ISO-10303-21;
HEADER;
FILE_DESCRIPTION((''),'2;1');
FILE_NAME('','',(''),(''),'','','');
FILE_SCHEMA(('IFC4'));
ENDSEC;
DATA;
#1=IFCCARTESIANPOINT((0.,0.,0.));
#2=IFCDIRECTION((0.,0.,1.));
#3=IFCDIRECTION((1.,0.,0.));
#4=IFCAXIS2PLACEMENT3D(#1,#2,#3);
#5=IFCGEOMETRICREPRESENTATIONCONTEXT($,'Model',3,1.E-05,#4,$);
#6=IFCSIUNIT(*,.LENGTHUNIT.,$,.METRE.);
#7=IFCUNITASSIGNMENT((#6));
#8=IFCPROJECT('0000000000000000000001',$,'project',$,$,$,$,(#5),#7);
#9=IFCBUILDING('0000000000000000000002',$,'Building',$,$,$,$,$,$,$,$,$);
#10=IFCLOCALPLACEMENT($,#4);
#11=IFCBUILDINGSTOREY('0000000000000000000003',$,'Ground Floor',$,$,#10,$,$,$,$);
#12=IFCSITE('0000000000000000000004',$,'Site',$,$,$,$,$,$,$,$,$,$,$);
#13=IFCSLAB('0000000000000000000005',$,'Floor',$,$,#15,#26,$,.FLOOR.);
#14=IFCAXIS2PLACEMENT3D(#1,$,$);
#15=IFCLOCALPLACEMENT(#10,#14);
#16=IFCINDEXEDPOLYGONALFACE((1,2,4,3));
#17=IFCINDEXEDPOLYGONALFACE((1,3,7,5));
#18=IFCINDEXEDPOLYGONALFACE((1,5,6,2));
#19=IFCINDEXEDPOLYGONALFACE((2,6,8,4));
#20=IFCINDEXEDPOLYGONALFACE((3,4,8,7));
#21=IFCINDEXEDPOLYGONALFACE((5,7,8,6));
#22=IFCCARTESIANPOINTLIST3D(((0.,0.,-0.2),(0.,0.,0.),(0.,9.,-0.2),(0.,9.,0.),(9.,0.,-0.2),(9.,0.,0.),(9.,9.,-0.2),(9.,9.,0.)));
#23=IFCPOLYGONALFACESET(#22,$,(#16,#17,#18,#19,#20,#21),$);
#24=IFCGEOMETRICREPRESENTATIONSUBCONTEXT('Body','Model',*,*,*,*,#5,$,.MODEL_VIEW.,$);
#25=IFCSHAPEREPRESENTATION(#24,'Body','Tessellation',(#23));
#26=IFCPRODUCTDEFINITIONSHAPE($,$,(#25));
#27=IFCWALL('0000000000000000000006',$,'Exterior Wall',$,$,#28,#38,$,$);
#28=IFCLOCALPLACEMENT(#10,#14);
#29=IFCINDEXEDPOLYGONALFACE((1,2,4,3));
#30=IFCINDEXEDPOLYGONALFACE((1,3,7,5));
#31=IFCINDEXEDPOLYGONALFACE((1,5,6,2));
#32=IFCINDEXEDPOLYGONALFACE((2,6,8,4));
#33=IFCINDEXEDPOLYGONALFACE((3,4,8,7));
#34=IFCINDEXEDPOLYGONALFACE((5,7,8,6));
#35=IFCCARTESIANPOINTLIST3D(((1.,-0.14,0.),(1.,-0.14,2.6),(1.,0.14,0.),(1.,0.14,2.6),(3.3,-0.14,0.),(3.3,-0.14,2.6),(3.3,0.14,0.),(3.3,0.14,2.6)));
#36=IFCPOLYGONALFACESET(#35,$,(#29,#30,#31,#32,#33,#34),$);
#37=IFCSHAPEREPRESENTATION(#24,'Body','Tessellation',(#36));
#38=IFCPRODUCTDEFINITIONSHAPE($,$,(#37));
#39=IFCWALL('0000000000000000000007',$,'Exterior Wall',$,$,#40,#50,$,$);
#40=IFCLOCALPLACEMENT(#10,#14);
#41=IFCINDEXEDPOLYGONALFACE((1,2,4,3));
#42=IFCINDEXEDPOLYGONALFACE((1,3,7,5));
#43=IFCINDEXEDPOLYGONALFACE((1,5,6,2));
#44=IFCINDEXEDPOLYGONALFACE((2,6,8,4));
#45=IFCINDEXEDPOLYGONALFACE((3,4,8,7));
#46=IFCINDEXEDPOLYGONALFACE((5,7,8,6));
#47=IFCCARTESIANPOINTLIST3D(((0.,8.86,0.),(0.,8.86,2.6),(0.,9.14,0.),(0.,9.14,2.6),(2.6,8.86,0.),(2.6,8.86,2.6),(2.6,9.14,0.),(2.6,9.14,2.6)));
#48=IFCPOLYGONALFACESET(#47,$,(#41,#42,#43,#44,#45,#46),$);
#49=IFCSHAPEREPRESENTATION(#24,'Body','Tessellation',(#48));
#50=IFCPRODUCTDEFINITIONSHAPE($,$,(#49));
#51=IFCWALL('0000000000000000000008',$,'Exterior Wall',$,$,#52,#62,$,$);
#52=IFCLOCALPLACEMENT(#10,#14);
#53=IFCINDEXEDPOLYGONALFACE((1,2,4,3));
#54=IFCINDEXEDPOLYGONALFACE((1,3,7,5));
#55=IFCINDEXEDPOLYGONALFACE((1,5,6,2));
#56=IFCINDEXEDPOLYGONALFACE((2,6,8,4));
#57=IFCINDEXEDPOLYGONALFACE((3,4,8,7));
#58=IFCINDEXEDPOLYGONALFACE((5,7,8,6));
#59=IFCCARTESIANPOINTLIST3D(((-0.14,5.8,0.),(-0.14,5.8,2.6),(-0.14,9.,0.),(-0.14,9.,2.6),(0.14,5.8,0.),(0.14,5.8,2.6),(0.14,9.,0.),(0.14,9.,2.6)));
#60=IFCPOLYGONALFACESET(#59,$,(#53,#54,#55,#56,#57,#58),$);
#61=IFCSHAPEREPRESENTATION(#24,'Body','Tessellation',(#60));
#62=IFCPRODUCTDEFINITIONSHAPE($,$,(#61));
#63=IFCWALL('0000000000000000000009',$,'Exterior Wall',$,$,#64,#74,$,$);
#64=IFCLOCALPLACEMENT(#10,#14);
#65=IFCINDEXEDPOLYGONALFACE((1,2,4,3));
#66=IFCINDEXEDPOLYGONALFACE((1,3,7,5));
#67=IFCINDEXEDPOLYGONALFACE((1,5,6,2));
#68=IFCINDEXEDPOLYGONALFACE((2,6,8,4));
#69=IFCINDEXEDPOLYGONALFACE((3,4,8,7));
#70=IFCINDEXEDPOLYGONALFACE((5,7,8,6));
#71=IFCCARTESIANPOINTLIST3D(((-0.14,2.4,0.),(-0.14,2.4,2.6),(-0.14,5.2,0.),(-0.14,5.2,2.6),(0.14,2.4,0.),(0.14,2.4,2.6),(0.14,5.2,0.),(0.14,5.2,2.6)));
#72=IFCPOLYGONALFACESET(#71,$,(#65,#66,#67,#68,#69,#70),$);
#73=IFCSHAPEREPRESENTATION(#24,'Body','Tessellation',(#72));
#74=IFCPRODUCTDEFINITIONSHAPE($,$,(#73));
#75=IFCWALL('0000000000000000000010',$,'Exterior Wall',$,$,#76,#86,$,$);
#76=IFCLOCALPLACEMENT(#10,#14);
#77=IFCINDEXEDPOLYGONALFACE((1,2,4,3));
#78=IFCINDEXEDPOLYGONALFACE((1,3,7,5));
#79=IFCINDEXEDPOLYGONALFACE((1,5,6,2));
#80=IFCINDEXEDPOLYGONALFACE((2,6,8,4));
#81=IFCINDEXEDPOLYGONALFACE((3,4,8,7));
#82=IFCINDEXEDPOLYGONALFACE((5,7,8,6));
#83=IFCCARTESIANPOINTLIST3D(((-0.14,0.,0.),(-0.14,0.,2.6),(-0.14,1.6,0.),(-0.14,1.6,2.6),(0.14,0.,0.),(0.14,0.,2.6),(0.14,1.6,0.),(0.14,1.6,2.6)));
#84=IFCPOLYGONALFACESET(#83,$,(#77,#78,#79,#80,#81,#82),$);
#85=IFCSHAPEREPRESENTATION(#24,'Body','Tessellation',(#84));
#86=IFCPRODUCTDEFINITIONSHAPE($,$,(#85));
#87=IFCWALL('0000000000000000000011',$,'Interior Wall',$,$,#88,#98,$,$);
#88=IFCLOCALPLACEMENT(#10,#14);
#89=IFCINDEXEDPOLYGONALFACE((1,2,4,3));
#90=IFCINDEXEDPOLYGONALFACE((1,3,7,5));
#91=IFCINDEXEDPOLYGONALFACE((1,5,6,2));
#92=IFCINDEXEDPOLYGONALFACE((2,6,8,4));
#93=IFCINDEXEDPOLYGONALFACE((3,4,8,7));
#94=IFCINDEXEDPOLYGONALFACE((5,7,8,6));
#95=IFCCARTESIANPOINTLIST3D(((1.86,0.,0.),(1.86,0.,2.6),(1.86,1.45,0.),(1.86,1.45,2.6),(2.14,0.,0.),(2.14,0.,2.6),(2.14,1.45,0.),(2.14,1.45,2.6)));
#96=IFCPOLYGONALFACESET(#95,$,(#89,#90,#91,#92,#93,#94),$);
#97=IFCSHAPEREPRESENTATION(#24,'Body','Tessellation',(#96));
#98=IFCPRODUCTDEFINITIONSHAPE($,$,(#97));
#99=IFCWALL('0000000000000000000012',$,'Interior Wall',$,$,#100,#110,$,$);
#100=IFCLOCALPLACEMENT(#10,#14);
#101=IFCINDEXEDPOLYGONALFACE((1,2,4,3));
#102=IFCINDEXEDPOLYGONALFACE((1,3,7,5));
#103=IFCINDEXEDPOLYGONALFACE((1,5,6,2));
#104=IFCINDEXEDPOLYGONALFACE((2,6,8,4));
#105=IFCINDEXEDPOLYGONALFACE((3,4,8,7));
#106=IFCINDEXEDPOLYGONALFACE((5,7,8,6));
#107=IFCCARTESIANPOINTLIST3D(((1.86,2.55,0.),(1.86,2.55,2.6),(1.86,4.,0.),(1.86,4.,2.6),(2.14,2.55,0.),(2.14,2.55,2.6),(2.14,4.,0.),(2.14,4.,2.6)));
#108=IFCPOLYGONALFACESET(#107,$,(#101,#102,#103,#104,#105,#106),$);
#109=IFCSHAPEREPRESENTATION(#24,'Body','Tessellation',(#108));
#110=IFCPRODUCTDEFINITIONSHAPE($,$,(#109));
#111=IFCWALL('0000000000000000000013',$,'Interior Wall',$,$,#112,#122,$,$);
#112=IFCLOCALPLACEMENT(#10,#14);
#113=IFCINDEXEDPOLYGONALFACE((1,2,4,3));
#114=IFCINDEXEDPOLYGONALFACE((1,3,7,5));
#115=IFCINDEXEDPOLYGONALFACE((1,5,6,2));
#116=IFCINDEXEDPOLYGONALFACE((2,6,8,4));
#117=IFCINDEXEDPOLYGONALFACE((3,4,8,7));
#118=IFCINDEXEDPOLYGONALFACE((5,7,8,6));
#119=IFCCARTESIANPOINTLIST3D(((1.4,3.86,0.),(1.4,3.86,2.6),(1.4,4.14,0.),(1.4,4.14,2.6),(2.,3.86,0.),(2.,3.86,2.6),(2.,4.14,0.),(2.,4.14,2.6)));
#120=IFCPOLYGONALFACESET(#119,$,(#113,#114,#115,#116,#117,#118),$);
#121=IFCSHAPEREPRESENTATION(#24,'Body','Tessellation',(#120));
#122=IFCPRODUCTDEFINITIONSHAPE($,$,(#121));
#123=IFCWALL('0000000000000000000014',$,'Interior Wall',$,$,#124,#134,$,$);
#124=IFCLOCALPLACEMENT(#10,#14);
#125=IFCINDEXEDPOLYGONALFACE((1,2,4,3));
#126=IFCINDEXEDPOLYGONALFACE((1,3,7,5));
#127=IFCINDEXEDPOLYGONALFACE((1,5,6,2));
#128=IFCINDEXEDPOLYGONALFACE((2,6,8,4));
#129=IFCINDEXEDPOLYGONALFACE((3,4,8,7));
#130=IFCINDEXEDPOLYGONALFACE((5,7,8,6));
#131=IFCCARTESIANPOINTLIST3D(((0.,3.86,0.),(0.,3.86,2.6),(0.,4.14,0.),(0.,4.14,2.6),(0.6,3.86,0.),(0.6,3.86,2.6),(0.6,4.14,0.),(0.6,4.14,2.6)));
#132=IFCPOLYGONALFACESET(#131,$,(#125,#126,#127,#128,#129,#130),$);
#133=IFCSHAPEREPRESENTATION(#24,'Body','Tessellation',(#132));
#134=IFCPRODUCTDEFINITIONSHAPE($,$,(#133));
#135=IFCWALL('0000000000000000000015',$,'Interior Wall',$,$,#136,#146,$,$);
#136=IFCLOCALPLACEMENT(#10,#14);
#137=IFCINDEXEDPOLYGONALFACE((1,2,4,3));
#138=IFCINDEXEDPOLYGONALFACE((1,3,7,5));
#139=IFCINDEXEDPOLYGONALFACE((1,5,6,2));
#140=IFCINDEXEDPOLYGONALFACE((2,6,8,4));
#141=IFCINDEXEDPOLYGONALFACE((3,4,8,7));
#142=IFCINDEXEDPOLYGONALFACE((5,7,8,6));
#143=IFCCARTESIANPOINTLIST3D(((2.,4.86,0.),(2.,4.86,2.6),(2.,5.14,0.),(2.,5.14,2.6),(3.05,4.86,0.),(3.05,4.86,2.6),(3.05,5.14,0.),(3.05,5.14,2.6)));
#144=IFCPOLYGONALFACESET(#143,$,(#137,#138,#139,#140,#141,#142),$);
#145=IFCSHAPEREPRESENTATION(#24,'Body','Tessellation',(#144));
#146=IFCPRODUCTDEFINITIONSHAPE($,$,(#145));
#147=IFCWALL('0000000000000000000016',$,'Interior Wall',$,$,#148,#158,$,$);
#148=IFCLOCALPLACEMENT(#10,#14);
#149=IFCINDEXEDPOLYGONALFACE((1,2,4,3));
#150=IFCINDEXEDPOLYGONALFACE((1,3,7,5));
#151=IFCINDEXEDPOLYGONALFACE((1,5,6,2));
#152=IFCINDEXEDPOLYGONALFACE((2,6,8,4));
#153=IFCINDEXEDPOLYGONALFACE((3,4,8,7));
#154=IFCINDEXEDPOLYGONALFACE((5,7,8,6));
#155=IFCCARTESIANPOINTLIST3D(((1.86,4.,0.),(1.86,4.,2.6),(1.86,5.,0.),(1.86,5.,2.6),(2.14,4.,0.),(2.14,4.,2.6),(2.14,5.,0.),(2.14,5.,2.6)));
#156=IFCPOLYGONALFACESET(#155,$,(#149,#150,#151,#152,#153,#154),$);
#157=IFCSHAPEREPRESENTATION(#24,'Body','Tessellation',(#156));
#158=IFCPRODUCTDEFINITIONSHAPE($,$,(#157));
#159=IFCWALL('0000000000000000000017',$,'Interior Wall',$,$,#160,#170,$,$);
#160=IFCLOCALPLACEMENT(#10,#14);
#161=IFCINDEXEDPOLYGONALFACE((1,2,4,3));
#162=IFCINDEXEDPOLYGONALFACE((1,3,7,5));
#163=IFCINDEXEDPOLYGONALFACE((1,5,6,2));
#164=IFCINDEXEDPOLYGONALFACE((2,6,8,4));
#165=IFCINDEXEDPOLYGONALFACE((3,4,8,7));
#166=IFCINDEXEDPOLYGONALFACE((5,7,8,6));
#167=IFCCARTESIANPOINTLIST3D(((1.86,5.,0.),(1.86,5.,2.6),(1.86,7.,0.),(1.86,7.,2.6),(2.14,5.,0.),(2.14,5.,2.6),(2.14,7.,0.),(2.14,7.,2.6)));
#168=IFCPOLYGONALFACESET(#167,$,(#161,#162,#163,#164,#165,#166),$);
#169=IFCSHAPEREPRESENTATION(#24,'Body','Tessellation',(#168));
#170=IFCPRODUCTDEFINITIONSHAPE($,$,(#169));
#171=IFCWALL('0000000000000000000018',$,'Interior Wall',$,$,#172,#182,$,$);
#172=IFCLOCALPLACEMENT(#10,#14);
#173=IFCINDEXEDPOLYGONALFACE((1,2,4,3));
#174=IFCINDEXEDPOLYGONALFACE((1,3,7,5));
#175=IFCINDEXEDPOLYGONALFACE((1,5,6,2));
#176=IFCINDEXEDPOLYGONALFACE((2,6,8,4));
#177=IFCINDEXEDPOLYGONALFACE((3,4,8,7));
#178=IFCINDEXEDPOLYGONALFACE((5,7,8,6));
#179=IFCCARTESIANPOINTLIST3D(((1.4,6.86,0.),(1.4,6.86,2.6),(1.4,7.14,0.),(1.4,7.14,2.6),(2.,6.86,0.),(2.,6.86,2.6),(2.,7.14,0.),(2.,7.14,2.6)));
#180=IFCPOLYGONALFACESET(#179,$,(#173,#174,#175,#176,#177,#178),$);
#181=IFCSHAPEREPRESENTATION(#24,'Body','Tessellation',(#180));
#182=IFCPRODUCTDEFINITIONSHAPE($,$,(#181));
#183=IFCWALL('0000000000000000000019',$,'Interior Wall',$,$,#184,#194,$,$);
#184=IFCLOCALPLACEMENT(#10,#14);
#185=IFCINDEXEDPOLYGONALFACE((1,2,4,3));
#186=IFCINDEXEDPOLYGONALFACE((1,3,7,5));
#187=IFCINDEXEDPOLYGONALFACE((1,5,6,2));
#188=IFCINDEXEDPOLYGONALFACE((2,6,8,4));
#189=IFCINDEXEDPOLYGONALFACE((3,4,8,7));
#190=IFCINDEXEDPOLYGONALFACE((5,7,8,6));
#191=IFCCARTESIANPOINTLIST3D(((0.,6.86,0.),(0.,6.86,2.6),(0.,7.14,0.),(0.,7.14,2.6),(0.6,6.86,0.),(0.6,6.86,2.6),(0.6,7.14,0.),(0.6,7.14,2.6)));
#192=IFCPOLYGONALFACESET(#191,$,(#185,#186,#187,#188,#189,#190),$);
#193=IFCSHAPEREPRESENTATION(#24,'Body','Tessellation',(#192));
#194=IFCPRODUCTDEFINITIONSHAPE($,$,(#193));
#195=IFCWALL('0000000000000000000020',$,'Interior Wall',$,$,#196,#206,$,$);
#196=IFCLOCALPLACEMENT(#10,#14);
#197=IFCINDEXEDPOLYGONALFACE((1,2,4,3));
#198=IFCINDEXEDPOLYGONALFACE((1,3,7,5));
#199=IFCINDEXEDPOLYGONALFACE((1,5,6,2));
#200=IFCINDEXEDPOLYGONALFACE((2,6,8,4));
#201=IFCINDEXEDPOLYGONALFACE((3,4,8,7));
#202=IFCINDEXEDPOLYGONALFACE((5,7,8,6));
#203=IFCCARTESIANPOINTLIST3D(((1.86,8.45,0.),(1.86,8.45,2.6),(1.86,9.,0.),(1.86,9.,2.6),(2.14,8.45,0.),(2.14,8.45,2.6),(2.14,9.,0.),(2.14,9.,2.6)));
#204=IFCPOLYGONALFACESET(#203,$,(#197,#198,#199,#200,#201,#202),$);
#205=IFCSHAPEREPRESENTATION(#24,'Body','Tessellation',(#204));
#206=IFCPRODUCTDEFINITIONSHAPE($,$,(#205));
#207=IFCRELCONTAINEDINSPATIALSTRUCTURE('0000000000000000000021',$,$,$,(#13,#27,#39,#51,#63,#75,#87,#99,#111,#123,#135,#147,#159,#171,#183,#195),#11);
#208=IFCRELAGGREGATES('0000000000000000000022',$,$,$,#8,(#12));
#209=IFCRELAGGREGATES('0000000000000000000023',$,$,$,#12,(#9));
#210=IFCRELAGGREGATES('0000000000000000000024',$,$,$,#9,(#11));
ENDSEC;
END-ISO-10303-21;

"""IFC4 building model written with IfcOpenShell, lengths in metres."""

from ifc_helpers import new_model, si_unit, frame, origin_with_axes, place, context, subcontext, project, spatial, indexed_curve, outline, extrude, element, save


model = new_model("IFC4")

# Units and contexts
model_context = context("Model", 3, precision=1e-05, world=origin_with_axes())
body_context = subcontext(model_context, "Body", "Model", "MODEL_VIEW")
ifc_project = project(units=[si_unit("LENGTHUNIT", "METRE")], contexts=[model_context])

# Site, building, storey
site = spatial("IfcSite", under=ifc_project, Name="Site")
building = spatial("IfcBuilding", under=site, Name="Building")
storey_placement = place(None, origin_with_axes())
storey = spatial("IfcBuildingStorey", under=building, at=storey_placement, Name="Ground Floor")

# Slab
slab_placement = place(storey_placement, frame((0.0, 0.0, -0.2), z_axis=(0.0, 0.0, 1.0), x_axis=(1.0, 0.0, 0.0)))
element("IfcSlab", 1, at=slab_placement, inside=storey, Name="Floor", PredefinedType="FLOOR", context=body_context, shape_type="SweptSolid", body=[
    extrude(outline(indexed_curve([(0.0, 0.0), (9.0, 0.0), (9.0, 9.0), (0.0, 9.0)])), None, (0.0, 0.0, 1.0), 0.2),
])

# Walls
wall_1_placement = place(storey_placement, frame((1.0, 0.0, 0.0), z_axis=(0.0, 0.0, 1.0), x_axis=(1.0, 0.0, 0.0)))
element("IfcWall", 2, at=wall_1_placement, inside=storey, Name="Exterior Wall", context=body_context, shape_type="SweptSolid", body=[
    extrude(outline(indexed_curve([(0.0, 0.0), (0.0, 0.28), (2.3, 0.28), (2.3, 0.0), (0.0, 0.0)], self_intersect=False)), frame((0.0, -0.14, 0.0), z_axis=(0.0, 0.0, 1.0), x_axis=(1.0, 0.0, 0.0)), (0.0, 0.0, 1.0), 2.6),
])
wall_2_placement = place(storey_placement, frame((2.6, 9.0, 0.0), z_axis=(0.0, 0.0, 1.0), x_axis=(-1.0, 0.0, 0.0)))
element("IfcWall", 3, at=wall_2_placement, inside=storey, Name="Exterior Wall", context=body_context, shape_type="SweptSolid", body=[
    extrude(outline(indexed_curve([(0.0, 0.0), (0.0, 0.28), (2.6, 0.28), (2.6, 0.0), (0.0, 0.0)], self_intersect=False)), frame((0.0, -0.14, 0.0), z_axis=(0.0, 0.0, 1.0), x_axis=(1.0, 0.0, 0.0)), (0.0, 0.0, 1.0), 2.6),
])
wall_3_placement = place(storey_placement, frame((0.0, 9.0, 0.0), z_axis=(0.0, 0.0, 1.0), x_axis=(0.0, -1.0, 0.0)))
element("IfcWall", 4, at=wall_3_placement, inside=storey, Name="Exterior Wall", context=body_context, shape_type="SweptSolid", body=[
    extrude(outline(indexed_curve([(0.0, 0.0), (0.0, 0.28), (3.2, 0.28), (3.2, 0.0), (0.0, 0.0)], self_intersect=False)), frame((0.0, -0.14, 0.0), z_axis=(0.0, 0.0, 1.0), x_axis=(1.0, 0.0, 0.0)), (0.0, 0.0, 1.0), 2.6),
])
wall_4_placement = place(storey_placement, frame((0.0, 5.2, 0.0), z_axis=(0.0, 0.0, 1.0), x_axis=(0.0, -1.0, 0.0)))
element("IfcWall", 5, at=wall_4_placement, inside=storey, Name="Exterior Wall", context=body_context, shape_type="SweptSolid", body=[
    extrude(outline(indexed_curve([(0.0, 0.0), (0.0, 0.28), (2.8, 0.28), (2.8, 0.0), (0.0, 0.0)], self_intersect=False)), frame((0.0, -0.14, 0.0), z_axis=(0.0, 0.0, 1.0), x_axis=(1.0, 0.0, 0.0)), (0.0, 0.0, 1.0), 2.6),
])
wall_5_placement = place(storey_placement, frame((0.0, 1.6, 0.0), z_axis=(0.0, 0.0, 1.0), x_axis=(0.0, -1.0, 0.0)))
element("IfcWall", 6, at=wall_5_placement, inside=storey, Name="Exterior Wall", context=body_context, shape_type="SweptSolid", body=[
    extrude(outline(indexed_curve([(0.0, 0.0), (0.0, 0.28), (1.6, 0.28), (1.6, 0.0), (0.0, 0.0)], self_intersect=False)), frame((0.0, -0.14, 0.0), z_axis=(0.0, 0.0, 1.0), x_axis=(1.0, 0.0, 0.0)), (0.0, 0.0, 1.0), 2.6),
])
wall_6_placement = place(storey_placement, frame((2.0, 0.0, 0.0), z_axis=(0.0, 0.0, 1.0), x_axis=(0.0, 1.0, 0.0)))
element("IfcWall", 7, at=wall_6_placement, inside=storey, Name="Interior Wall", context=body_context, shape_type="SweptSolid", body=[
    extrude(outline(indexed_curve([(0.0, 0.0), (0.0, 0.28), (1.45, 0.28), (1.45, 0.0), (0.0, 0.0)], self_intersect=False)), frame((0.0, -0.14, 0.0), z_axis=(0.0, 0.0, 1.0), x_axis=(1.0, 0.0, 0.0)), (0.0, 0.0, 1.0), 2.6),
])
wall_7_placement = place(storey_placement, frame((2.0, 2.55, 0.0), z_axis=(0.0, 0.0, 1.0), x_axis=(0.0, 1.0, 0.0)))
element("IfcWall", 8, at=wall_7_placement, inside=storey, Name="Interior Wall", context=body_context, shape_type="SweptSolid", body=[
    extrude(outline(indexed_curve([(0.0, 0.0), (0.0, 0.28), (1.45, 0.28), (1.45, 0.0), (0.0, 0.0)], self_intersect=False)), frame((0.0, -0.14, 0.0), z_axis=(0.0, 0.0, 1.0), x_axis=(1.0, 0.0, 0.0)), (0.0, 0.0, 1.0), 2.6),
])
for number, where, z_axis, x_axis, name in (
    (9, (2.0, 4.0, 0.0), (0.0, 0.0, 1.0), (-1.0, 0.0, 0.0), "Interior Wall"),
    (10, (0.6, 4.0, 0.0), (0.0, 0.0, 1.0), (-1.0, 0.0, 0.0), "Interior Wall"),
):
    element("IfcWall", number, at=place(storey_placement, frame(where, z_axis=z_axis, x_axis=x_axis)), inside=storey, Name=name, context=body_context, shape_type="SweptSolid", body=[
        extrude(outline(indexed_curve([(0.0, 0.0), (0.0, 0.28), (0.6, 0.28), (0.6, 0.0), (0.0, 0.0)], self_intersect=False)), frame((0.0, -0.14, 0.0), z_axis=(0.0, 0.0, 1.0), x_axis=(1.0, 0.0, 0.0)), (0.0, 0.0, 1.0), 2.6),
    ])
wall_8_placement = place(storey_placement, frame((3.05, 5.0, 0.0), z_axis=(0.0, 0.0, 1.0), x_axis=(-1.0, 0.0, 0.0)))
element("IfcWall", 11, at=wall_8_placement, inside=storey, Name="Interior Wall", context=body_context, shape_type="SweptSolid", body=[
    extrude(outline(indexed_curve([(0.0, 0.0), (0.0, 0.28), (1.05, 0.28), (1.05, 0.0), (0.0, 0.0)], self_intersect=False)), frame((0.0, -0.14, 0.0), z_axis=(0.0, 0.0, 1.0), x_axis=(1.0, 0.0, 0.0)), (0.0, 0.0, 1.0), 2.6),
])
wall_9_placement = place(storey_placement, frame((2.0, 5.0, 0.0), z_axis=(0.0, 0.0, 1.0), x_axis=(0.0, -1.0, 0.0)))
element("IfcWall", 12, at=wall_9_placement, inside=storey, Name="Interior Wall", context=body_context, shape_type="SweptSolid", body=[
    extrude(outline(indexed_curve([(0.0, 0.0), (0.0, 0.28), (1.0, 0.28), (1.0, 0.0), (0.0, 0.0)], self_intersect=False)), frame((0.0, -0.14, 0.0), z_axis=(0.0, 0.0, 1.0), x_axis=(1.0, 0.0, 0.0)), (0.0, 0.0, 1.0), 2.6),
])
wall_10_placement = place(storey_placement, frame((2.0, 5.0, 0.0), z_axis=(0.0, 0.0, 1.0), x_axis=(0.0, 1.0, 0.0)))
element("IfcWall", 13, at=wall_10_placement, inside=storey, Name="Interior Wall", context=body_context, shape_type="SweptSolid", body=[
    extrude(outline(indexed_curve([(0.0, 0.0), (0.0, 0.28), (2.0, 0.28), (2.0, 0.0), (0.0, 0.0)], self_intersect=False)), frame((0.0, -0.14, 0.0), z_axis=(0.0, 0.0, 1.0), x_axis=(1.0, 0.0, 0.0)), (0.0, 0.0, 1.0), 2.6),
])
for number, where, z_axis, x_axis, name in (
    (14, (2.0, 7.0, 0.0), (0.0, 0.0, 1.0), (-1.0, 0.0, 0.0), "Interior Wall"),
    (15, (0.6, 7.0, 0.0), (0.0, 0.0, 1.0), (-1.0, 0.0, 0.0), "Interior Wall"),
):
    element("IfcWall", number, at=place(storey_placement, frame(where, z_axis=z_axis, x_axis=x_axis)), inside=storey, Name=name, context=body_context, shape_type="SweptSolid", body=[
        extrude(outline(indexed_curve([(0.0, 0.0), (0.0, 0.28), (0.6, 0.28), (0.6, 0.0), (0.0, 0.0)], self_intersect=False)), frame((0.0, -0.14, 0.0), z_axis=(0.0, 0.0, 1.0), x_axis=(1.0, 0.0, 0.0)), (0.0, 0.0, 1.0), 2.6),
    ])
wall_11_placement = place(storey_placement, frame((2.0, 9.0, 0.0), z_axis=(0.0, 0.0, 1.0), x_axis=(0.0, -1.0, 0.0)))
element("IfcWall", 16, at=wall_11_placement, inside=storey, Name="Interior Wall", context=body_context, shape_type="SweptSolid", body=[
    extrude(outline(indexed_curve([(0.0, 0.0), (0.0, 0.28), (0.55, 0.28), (0.55, 0.0), (0.0, 0.0)], self_intersect=False)), frame((0.0, -0.14, 0.0), z_axis=(0.0, 0.0, 1.0), x_axis=(1.0, 0.0, 0.0)), (0.0, 0.0, 1.0), 2.6),
])

save(model, "model.ifc")
